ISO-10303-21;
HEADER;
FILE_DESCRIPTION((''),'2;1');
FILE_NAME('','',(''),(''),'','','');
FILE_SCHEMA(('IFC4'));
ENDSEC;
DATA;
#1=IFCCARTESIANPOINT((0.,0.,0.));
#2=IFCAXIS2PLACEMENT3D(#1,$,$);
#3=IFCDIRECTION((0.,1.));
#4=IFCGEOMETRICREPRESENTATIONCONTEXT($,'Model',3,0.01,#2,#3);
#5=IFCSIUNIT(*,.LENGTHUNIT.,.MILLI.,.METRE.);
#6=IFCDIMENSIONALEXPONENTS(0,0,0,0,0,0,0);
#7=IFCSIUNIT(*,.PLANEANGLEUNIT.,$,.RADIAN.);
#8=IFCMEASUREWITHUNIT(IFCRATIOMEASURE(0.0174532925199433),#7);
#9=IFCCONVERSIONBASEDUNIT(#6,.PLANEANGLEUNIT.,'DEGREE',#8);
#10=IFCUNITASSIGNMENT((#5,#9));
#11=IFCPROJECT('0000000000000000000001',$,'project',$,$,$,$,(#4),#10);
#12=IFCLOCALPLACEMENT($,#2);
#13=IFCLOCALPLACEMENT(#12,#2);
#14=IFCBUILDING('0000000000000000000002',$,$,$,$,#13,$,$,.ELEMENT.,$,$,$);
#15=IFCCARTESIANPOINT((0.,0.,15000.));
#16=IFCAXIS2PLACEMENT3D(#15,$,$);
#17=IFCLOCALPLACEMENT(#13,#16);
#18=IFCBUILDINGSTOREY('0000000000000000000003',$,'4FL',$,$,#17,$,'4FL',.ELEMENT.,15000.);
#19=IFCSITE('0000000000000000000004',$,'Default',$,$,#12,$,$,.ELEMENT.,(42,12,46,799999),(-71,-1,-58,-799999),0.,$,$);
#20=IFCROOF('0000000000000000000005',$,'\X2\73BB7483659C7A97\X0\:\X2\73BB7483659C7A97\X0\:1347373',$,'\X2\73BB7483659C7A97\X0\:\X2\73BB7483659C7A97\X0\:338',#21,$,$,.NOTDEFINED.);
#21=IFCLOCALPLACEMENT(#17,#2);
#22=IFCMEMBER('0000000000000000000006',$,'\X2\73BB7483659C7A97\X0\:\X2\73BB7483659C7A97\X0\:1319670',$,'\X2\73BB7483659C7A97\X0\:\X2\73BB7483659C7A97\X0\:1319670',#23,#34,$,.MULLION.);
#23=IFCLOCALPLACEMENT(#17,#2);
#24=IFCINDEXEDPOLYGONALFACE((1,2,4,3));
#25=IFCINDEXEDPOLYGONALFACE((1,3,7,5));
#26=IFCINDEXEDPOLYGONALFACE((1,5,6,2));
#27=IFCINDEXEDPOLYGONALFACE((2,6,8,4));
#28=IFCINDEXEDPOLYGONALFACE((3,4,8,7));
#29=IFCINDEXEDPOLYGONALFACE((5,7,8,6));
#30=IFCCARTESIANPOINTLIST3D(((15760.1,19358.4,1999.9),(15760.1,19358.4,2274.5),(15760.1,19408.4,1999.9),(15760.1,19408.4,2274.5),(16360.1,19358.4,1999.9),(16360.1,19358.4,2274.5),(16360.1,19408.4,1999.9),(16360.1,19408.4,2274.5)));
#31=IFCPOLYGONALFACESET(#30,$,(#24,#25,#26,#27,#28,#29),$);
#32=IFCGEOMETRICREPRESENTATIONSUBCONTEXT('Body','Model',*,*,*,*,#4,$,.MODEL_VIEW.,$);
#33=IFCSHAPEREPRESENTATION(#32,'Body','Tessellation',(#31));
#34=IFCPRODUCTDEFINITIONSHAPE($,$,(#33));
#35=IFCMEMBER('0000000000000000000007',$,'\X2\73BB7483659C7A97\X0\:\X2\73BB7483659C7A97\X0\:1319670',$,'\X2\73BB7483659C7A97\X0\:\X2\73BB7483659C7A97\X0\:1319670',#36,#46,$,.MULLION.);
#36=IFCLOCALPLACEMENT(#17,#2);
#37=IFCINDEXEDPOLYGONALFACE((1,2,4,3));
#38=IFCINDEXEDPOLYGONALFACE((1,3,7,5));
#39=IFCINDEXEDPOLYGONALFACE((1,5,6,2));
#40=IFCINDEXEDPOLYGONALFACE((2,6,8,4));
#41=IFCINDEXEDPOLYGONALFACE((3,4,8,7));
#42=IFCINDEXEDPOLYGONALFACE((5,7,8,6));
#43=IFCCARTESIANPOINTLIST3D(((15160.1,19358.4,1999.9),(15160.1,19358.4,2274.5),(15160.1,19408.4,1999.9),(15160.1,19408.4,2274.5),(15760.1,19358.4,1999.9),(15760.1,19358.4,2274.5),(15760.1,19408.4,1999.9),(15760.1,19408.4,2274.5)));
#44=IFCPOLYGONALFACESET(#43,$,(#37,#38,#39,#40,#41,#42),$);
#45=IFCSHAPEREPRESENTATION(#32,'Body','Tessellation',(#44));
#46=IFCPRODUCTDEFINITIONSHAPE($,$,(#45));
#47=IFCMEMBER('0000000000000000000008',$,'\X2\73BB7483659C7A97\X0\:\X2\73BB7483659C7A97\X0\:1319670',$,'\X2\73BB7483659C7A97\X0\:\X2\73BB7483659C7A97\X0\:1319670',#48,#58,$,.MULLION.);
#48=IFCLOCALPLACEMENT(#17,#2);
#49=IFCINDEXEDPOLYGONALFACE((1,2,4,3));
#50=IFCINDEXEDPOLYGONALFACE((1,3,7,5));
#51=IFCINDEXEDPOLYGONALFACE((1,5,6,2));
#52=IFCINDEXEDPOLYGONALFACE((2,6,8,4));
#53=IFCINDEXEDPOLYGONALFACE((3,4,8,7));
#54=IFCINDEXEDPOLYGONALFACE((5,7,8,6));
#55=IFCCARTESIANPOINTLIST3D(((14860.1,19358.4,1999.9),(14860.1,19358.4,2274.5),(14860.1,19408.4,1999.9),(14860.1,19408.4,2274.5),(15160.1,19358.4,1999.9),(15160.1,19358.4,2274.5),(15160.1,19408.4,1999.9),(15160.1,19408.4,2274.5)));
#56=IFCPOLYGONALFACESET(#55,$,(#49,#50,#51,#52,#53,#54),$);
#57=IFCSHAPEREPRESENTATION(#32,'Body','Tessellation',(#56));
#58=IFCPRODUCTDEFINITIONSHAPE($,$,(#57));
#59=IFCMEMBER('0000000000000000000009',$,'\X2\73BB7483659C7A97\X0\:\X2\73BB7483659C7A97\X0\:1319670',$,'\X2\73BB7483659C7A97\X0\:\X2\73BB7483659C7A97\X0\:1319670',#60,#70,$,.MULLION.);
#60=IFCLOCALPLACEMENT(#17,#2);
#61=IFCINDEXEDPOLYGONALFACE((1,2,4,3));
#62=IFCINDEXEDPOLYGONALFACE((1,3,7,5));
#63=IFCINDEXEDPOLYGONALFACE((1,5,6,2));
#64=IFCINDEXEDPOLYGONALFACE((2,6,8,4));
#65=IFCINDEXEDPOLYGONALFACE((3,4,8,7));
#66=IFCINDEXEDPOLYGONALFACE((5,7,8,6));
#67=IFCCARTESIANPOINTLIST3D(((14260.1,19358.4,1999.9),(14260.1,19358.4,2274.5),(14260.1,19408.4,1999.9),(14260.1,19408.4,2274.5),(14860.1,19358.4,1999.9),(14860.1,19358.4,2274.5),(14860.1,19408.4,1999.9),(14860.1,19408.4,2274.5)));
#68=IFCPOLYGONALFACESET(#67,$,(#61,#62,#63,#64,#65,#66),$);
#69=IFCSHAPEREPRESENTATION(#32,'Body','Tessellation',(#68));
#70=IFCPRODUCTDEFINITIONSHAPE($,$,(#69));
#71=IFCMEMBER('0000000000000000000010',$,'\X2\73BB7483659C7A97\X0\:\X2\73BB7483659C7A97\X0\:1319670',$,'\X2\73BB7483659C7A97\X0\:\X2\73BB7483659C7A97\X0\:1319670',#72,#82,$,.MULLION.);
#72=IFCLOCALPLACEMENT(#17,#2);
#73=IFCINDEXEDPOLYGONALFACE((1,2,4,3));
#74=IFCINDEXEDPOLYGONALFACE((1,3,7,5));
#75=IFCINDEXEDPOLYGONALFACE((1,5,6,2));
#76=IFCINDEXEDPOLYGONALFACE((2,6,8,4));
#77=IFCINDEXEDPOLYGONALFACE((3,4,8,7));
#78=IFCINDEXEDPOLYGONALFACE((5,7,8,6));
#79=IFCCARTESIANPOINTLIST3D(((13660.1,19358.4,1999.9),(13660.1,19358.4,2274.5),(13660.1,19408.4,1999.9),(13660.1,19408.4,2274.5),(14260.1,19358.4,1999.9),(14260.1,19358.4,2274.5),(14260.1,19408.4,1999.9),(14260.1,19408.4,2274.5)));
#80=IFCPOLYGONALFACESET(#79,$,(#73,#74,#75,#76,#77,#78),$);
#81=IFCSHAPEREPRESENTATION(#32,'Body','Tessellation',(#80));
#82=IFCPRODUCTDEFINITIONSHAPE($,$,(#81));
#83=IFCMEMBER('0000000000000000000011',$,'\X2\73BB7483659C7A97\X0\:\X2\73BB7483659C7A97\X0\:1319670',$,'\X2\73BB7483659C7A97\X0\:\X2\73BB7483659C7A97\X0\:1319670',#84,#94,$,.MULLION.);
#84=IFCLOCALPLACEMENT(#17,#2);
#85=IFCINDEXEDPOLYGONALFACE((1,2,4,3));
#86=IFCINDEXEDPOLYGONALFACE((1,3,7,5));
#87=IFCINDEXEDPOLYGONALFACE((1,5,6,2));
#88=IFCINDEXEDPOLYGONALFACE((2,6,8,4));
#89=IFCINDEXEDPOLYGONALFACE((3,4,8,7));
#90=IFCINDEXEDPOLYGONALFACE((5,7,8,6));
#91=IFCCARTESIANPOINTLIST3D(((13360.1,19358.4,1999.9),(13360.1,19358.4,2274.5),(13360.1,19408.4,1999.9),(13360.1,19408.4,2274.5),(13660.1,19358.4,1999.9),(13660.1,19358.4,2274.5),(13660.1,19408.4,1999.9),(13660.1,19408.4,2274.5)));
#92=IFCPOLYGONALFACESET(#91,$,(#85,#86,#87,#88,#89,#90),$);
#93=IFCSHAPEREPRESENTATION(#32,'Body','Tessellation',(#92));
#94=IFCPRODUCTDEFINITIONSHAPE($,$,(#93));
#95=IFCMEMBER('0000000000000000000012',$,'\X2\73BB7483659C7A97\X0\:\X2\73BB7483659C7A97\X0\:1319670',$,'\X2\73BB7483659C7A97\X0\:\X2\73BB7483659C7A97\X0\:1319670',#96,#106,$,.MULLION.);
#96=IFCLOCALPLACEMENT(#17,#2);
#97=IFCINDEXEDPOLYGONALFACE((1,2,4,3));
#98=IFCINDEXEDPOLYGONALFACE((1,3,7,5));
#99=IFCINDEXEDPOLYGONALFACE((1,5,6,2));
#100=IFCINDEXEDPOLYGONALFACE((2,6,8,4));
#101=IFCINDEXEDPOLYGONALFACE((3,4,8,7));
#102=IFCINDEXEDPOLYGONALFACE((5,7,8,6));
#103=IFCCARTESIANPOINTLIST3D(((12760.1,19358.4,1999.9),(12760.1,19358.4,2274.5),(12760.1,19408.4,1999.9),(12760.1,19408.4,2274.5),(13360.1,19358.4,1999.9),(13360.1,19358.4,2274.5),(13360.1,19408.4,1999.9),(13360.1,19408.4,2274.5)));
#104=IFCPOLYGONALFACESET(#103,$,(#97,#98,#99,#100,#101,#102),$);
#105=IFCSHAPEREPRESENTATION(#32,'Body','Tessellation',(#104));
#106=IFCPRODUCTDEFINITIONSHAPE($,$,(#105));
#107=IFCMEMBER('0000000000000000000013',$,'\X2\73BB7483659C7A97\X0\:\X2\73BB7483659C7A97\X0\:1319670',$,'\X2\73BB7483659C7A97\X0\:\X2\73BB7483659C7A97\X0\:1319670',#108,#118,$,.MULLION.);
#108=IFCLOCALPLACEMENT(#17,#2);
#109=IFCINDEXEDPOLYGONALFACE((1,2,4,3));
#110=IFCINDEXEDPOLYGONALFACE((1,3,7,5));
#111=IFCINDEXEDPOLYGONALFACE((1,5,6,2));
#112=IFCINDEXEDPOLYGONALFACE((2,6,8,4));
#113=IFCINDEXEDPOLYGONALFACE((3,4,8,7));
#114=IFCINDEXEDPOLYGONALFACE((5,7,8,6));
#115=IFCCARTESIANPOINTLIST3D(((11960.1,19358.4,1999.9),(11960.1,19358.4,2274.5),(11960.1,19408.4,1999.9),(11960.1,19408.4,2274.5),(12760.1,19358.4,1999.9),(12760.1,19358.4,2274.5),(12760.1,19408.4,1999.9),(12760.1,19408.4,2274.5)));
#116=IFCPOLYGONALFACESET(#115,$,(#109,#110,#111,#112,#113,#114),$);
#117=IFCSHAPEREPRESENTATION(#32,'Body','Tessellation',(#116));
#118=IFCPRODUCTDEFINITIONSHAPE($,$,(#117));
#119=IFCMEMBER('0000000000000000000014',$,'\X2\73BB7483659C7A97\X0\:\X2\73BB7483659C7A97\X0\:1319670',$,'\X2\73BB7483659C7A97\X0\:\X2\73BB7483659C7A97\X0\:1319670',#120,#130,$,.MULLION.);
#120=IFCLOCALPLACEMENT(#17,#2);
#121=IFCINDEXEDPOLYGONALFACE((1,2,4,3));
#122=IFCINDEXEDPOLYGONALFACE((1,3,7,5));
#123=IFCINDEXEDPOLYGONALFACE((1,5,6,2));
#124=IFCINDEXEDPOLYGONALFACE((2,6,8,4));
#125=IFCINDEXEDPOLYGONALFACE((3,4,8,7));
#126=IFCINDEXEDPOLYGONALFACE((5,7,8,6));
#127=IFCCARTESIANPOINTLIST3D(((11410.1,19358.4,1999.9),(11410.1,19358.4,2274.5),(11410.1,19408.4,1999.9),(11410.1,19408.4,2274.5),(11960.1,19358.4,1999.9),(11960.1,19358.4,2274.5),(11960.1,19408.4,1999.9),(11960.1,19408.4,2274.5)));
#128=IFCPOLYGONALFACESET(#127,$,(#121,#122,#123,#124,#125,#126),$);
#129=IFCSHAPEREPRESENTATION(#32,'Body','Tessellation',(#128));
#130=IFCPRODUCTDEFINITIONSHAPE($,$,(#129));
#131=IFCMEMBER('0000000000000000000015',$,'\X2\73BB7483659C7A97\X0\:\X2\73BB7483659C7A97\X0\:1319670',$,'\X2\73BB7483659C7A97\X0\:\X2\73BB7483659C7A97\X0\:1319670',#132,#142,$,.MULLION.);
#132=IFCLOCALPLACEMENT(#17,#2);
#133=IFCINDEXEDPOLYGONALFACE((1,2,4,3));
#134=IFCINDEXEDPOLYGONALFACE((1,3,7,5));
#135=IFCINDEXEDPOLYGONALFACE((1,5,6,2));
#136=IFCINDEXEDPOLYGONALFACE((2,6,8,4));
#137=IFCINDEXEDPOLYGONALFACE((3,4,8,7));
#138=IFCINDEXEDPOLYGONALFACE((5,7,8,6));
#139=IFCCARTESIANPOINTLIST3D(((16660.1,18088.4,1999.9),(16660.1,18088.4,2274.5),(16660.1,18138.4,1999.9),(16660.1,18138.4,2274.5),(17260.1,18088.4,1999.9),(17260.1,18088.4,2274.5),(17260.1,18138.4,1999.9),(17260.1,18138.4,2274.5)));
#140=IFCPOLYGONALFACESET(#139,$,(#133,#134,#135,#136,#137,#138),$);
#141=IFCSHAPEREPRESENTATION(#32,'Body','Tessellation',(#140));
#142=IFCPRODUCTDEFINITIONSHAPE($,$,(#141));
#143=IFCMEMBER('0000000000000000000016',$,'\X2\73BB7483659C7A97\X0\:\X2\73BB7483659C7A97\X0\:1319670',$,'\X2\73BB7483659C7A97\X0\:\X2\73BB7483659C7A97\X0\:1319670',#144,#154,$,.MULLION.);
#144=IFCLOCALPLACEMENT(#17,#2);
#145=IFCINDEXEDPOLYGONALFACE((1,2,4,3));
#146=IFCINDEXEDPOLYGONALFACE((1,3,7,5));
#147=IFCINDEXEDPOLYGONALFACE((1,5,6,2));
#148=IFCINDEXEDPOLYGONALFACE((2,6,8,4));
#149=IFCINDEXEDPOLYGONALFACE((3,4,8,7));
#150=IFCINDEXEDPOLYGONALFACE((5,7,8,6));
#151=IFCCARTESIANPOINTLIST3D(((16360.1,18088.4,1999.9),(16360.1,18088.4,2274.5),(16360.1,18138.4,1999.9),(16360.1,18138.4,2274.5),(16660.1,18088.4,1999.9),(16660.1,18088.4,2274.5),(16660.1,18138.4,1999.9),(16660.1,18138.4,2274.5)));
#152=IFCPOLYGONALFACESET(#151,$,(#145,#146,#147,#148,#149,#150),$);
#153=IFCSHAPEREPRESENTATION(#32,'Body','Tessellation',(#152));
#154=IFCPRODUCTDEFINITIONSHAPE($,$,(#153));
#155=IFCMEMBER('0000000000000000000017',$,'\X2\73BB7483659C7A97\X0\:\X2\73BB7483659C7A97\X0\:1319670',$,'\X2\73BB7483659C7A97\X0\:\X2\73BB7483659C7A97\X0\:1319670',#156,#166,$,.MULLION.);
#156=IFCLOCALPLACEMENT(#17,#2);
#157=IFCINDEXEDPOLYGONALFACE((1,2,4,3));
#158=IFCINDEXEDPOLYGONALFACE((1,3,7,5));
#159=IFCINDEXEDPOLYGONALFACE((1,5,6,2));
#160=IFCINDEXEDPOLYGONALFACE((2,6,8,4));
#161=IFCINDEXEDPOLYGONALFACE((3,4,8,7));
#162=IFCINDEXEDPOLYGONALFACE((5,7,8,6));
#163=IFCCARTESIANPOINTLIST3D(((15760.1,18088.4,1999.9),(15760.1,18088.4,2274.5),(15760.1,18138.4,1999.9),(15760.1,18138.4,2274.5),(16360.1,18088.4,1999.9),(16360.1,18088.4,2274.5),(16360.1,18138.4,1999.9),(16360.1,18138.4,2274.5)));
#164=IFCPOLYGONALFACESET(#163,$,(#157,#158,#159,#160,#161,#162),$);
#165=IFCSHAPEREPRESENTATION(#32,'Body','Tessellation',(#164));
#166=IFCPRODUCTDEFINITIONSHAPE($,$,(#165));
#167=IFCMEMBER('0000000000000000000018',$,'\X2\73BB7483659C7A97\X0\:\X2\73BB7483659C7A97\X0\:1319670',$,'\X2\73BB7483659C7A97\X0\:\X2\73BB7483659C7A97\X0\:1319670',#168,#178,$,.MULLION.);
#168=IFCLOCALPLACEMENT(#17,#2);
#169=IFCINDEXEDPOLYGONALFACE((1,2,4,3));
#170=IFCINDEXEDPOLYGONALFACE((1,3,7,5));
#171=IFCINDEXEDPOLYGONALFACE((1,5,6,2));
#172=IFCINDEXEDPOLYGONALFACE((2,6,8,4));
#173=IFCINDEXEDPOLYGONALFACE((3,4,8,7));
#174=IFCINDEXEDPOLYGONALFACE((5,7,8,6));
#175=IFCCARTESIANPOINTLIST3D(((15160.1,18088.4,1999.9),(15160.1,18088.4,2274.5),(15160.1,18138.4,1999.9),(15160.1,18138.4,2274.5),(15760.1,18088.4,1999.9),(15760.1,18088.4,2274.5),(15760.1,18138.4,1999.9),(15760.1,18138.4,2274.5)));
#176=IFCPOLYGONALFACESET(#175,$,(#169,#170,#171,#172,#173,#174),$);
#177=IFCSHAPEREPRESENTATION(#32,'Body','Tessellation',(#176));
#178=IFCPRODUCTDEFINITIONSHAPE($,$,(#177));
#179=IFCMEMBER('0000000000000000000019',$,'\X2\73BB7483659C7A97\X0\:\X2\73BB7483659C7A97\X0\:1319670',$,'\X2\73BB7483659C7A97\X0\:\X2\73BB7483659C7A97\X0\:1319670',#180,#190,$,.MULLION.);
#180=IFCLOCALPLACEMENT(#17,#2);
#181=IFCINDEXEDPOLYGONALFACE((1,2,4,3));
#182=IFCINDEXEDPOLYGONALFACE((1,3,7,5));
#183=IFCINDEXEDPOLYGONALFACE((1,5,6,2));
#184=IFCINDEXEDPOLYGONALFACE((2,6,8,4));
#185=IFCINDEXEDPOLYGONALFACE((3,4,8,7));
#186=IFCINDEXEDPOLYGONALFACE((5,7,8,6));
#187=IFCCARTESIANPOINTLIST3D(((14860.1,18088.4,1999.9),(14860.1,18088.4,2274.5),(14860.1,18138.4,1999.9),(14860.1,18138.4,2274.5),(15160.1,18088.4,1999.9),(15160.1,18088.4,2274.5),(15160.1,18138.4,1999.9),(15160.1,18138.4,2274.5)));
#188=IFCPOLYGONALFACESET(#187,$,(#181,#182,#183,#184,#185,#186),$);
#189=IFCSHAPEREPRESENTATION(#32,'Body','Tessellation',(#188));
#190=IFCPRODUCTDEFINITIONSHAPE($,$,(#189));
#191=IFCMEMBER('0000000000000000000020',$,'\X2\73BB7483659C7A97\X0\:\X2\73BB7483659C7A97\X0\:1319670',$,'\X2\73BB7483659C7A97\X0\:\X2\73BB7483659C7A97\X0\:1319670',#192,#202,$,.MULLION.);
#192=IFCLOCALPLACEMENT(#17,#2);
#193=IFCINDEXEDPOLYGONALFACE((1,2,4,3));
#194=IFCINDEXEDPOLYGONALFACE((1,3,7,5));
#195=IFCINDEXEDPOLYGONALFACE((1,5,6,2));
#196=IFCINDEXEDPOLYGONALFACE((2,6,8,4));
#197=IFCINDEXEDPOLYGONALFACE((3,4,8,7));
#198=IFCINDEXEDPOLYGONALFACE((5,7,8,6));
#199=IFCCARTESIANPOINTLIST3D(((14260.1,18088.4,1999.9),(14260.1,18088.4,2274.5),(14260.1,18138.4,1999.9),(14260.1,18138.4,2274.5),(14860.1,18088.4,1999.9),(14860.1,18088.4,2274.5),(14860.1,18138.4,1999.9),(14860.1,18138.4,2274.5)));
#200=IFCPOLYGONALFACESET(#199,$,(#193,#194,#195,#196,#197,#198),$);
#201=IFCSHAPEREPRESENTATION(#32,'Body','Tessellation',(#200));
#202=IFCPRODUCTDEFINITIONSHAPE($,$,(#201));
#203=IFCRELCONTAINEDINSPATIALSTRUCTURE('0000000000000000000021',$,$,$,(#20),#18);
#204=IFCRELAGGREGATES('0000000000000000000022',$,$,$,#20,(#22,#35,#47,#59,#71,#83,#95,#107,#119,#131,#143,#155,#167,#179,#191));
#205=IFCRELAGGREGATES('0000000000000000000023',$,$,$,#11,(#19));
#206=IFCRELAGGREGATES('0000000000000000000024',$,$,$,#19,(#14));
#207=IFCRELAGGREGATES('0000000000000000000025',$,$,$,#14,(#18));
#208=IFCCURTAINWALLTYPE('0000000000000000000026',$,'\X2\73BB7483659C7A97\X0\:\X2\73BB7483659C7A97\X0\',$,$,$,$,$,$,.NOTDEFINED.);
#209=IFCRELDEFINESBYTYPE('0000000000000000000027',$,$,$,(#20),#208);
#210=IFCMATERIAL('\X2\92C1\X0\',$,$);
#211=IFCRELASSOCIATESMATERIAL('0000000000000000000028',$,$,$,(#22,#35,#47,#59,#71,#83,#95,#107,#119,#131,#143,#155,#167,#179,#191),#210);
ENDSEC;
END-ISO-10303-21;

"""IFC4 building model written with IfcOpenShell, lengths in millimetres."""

from ifc_helpers import new_model, entity, si_unit, converted_unit, direction, frame, frame_2d, origin, place, context, subcontext, project, spatial, rectangle, extrude, material, type_object, element, aggregate, save


model = new_model("IFC4")

# Units and contexts
model_context = context("Model", 3, precision=0.01, world=origin(), true_north=direction((0.0, 1.0)))
body_context = subcontext(model_context, "Body", "Model", "MODEL_VIEW")
ifc_project = project(units=[si_unit("LENGTHUNIT", "METRE", prefix="MILLI"), converted_unit("PLANEANGLEUNIT", "DEGREE", entity("IfcRatioMeasure", 0.0174532925199433), si_unit("PLANEANGLEUNIT", "RADIAN"), dimensions=[0, 0, 0, 0, 0, 0, 0])], contexts=[model_context])

# Site, building, storey
site_placement = place(None, origin())
site = spatial("IfcSite", under=ifc_project, at=site_placement, Name="Default", CompositionType="ELEMENT", RefLatitude=(42, 12, 46, 799999), RefLongitude=(-71, -1, -58, -799999), RefElevation=0.0)
building_placement = place(site_placement, origin())
building = spatial("IfcBuilding", under=site, at=building_placement, CompositionType="ELEMENT")
storey_placement = place(building_placement, frame((0.0, 0.0, 15000.0)))
storey = spatial("IfcBuildingStorey", under=building, at=storey_placement, Name="4FL", LongName="4FL", CompositionType="ELEMENT", Elevation=15000.0)

# Roof, members
curtain_wall_type = type_object("IfcCurtainWallType", Name="玻璃斜窗:玻璃斜窗", PredefinedType="NOTDEFINED")
roof_1_placement = place(storey_placement, frame((0.0, 0.0, -15000.0)))
roof_1 = element("IfcRoof", 1, at=roof_1_placement, inside=storey, type_object=curtain_wall_type, Name="玻璃斜窗:玻璃斜窗:1347373", ObjectType="玻璃斜窗:玻璃斜窗:338", PredefinedType="NOTDEFINED")
ifc_material = material(Name="鋁")
member_1_placement = place(roof_1_placement, frame((0.0, 0.0, 15000.0)))
member_1 = element("IfcMember", 2, at=member_1_placement, material=ifc_material, Name="玻璃斜窗:玻璃斜窗:1319670", ObjectType="玻璃斜窗:玻璃斜窗:1319670", PredefinedType="MULLION", context=body_context, shape_type="SweptSolid", body=[
    extrude(rectangle(XDim=274.5, YDim=50.0, at=frame_2d((0.0, 0.0), x_axis=(1.0, 0.0))), frame((15760.1, 19383.4, 2137.2), z_axis=(1.0, 0.0, 0.0), x_axis=(0.0, 0.0, -1.0)), (0.0, 0.0, 1.0), 600.0),
])
member_2_placement = place(roof_1_placement, frame((0.0, 0.0, 15000.0)))
member_2 = element("IfcMember", 3, at=member_2_placement, material=ifc_material, Name="玻璃斜窗:玻璃斜窗:1319670", ObjectType="玻璃斜窗:玻璃斜窗:1319670", PredefinedType="MULLION", context=body_context, shape_type="SweptSolid", body=[
    extrude(rectangle(XDim=274.5, YDim=50.0, at=frame_2d((0.0, 0.0), x_axis=(1.0, 0.0))), frame((15160.1, 19383.4, 2137.2), z_axis=(1.0, 0.0, 0.0), x_axis=(0.0, 0.0, -1.0)), (0.0, 0.0, 1.0), 600.0),
])
member_3_placement = place(roof_1_placement, frame((0.0, 0.0, 15000.0)))
member_3 = element("IfcMember", 4, at=member_3_placement, material=ifc_material, Name="玻璃斜窗:玻璃斜窗:1319670", ObjectType="玻璃斜窗:玻璃斜窗:1319670", PredefinedType="MULLION", context=body_context, shape_type="SweptSolid", body=[
    extrude(rectangle(XDim=274.5, YDim=50.0, at=frame_2d((0.0, 0.0), x_axis=(1.0, 0.0))), frame((14860.1, 19383.4, 2137.2), z_axis=(1.0, 0.0, 0.0), x_axis=(0.0, 0.0, -1.0)), (0.0, 0.0, 1.0), 300.0),
])
member_4_placement = place(roof_1_placement, frame((0.0, 0.0, 15000.0)))
member_4 = element("IfcMember", 5, at=member_4_placement, material=ifc_material, Name="玻璃斜窗:玻璃斜窗:1319670", ObjectType="玻璃斜窗:玻璃斜窗:1319670", PredefinedType="MULLION", context=body_context, shape_type="SweptSolid", body=[
    extrude(rectangle(XDim=274.5, YDim=50.0, at=frame_2d((0.0, 0.0), x_axis=(1.0, 0.0))), frame((14260.1, 19383.4, 2137.2), z_axis=(1.0, 0.0, 0.0), x_axis=(0.0, 0.0, -1.0)), (0.0, 0.0, 1.0), 600.0),
])
member_5_placement = place(roof_1_placement, frame((0.0, 0.0, 15000.0)))
member_5 = element("IfcMember", 6, at=member_5_placement, material=ifc_material, Name="玻璃斜窗:玻璃斜窗:1319670", ObjectType="玻璃斜窗:玻璃斜窗:1319670", PredefinedType="MULLION", context=body_context, shape_type="SweptSolid", body=[
    extrude(rectangle(XDim=274.5, YDim=50.0, at=frame_2d((0.0, 0.0), x_axis=(1.0, 0.0))), frame((13660.1, 19383.4, 2137.2), z_axis=(1.0, 0.0, 0.0), x_axis=(0.0, 0.0, -1.0)), (0.0, 0.0, 1.0), 600.0),
])
member_6_placement = place(roof_1_placement, frame((0.0, 0.0, 15000.0)))
member_6 = element("IfcMember", 7, at=member_6_placement, material=ifc_material, Name="玻璃斜窗:玻璃斜窗:1319670", ObjectType="玻璃斜窗:玻璃斜窗:1319670", PredefinedType="MULLION", context=body_context, shape_type="SweptSolid", body=[
    extrude(rectangle(XDim=274.5, YDim=50.0, at=frame_2d((0.0, 0.0), x_axis=(1.0, 0.0))), frame((13360.1, 19383.4, 2137.2), z_axis=(1.0, 0.0, 0.0), x_axis=(0.0, 0.0, -1.0)), (0.0, 0.0, 1.0), 300.0),
])
member_7_placement = place(roof_1_placement, frame((0.0, 0.0, 15000.0)))
member_7 = element("IfcMember", 8, at=member_7_placement, material=ifc_material, Name="玻璃斜窗:玻璃斜窗:1319670", ObjectType="玻璃斜窗:玻璃斜窗:1319670", PredefinedType="MULLION", context=body_context, shape_type="SweptSolid", body=[
    extrude(rectangle(XDim=274.5, YDim=50.0, at=frame_2d((0.0, 0.0), x_axis=(1.0, 0.0))), frame((12760.1, 19383.4, 2137.2), z_axis=(1.0, 0.0, 0.0), x_axis=(0.0, 0.0, -1.0)), (0.0, 0.0, 1.0), 600.0),
])
member_8_placement = place(roof_1_placement, frame((0.0, 0.0, 15000.0)))
member_8 = element("IfcMember", 9, at=member_8_placement, material=ifc_material, Name="玻璃斜窗:玻璃斜窗:1319670", ObjectType="玻璃斜窗:玻璃斜窗:1319670", PredefinedType="MULLION", context=body_context, shape_type="SweptSolid", body=[
    extrude(rectangle(XDim=274.5, YDim=50.0, at=frame_2d((0.0, 0.0), x_axis=(1.0, 0.0))), frame((11960.1, 19383.4, 2137.2), z_axis=(1.0, 0.0, 0.0), x_axis=(0.0, 0.0, -1.0)), (0.0, 0.0, 1.0), 800.0),
])
member_9_placement = place(roof_1_placement, frame((0.0, 0.0, 15000.0)))
member_9 = element("IfcMember", 10, at=member_9_placement, material=ifc_material, Name="玻璃斜窗:玻璃斜窗:1319670", ObjectType="玻璃斜窗:玻璃斜窗:1319670", PredefinedType="MULLION", context=body_context, shape_type="SweptSolid", body=[
    extrude(rectangle(XDim=274.5, YDim=50.0, at=frame_2d((0.0, 0.0), x_axis=(1.0, 0.0))), frame((11410.1, 19383.4, 2137.2), z_axis=(1.0, 0.0, 0.0), x_axis=(0.0, 0.0, -1.0)), (0.0, 0.0, 1.0), 550.0),
])
member_10_placement = place(roof_1_placement, frame((0.0, 0.0, 15000.0)))
member_10 = element("IfcMember", 11, at=member_10_placement, material=ifc_material, Name="玻璃斜窗:玻璃斜窗:1319670", ObjectType="玻璃斜窗:玻璃斜窗:1319670", PredefinedType="MULLION", context=body_context, shape_type="SweptSolid", body=[
    extrude(rectangle(XDim=274.5, YDim=50.0, at=frame_2d((0.0, 0.0), x_axis=(1.0, 0.0))), frame((17260.1, 18113.4, 2137.2), z_axis=(-1.0, 0.0, 0.0), x_axis=(0.0, 0.0, -1.0)), (0.0, 0.0, 1.0), 600.0),
])
member_11_placement = place(roof_1_placement, frame((0.0, 0.0, 15000.0)))
member_11 = element("IfcMember", 12, at=member_11_placement, material=ifc_material, Name="玻璃斜窗:玻璃斜窗:1319670", ObjectType="玻璃斜窗:玻璃斜窗:1319670", PredefinedType="MULLION", context=body_context, shape_type="SweptSolid", body=[
    extrude(rectangle(XDim=274.5, YDim=50.0, at=frame_2d((0.0, 0.0), x_axis=(1.0, 0.0))), frame((16660.1, 18113.4, 2137.2), z_axis=(-1.0, 0.0, 0.0), x_axis=(0.0, 0.0, -1.0)), (0.0, 0.0, 1.0), 300.0),
])
member_12_placement = place(roof_1_placement, frame((0.0, 0.0, 15000.0)))
member_12 = element("IfcMember", 13, at=member_12_placement, material=ifc_material, Name="玻璃斜窗:玻璃斜窗:1319670", ObjectType="玻璃斜窗:玻璃斜窗:1319670", PredefinedType="MULLION", context=body_context, shape_type="SweptSolid", body=[
    extrude(rectangle(XDim=274.5, YDim=50.0, at=frame_2d((0.0, 0.0), x_axis=(1.0, 0.0))), frame((16360.1, 18113.4, 2137.2), z_axis=(-1.0, 0.0, 0.0), x_axis=(0.0, 0.0, -1.0)), (0.0, 0.0, 1.0), 600.0),
])
member_13_placement = place(roof_1_placement, frame((0.0, 0.0, 15000.0)))
member_13 = element("IfcMember", 14, at=member_13_placement, material=ifc_material, Name="玻璃斜窗:玻璃斜窗:1319670", ObjectType="玻璃斜窗:玻璃斜窗:1319670", PredefinedType="MULLION", context=body_context, shape_type="SweptSolid", body=[
    extrude(rectangle(XDim=274.5, YDim=50.0, at=frame_2d((0.0, 0.0), x_axis=(1.0, 0.0))), frame((15760.1, 18113.4, 2137.2), z_axis=(-1.0, 0.0, 0.0), x_axis=(0.0, 0.0, -1.0)), (0.0, 0.0, 1.0), 600.0),
])
member_14_placement = place(roof_1_placement, frame((0.0, 0.0, 15000.0)))
member_14 = element("IfcMember", 15, at=member_14_placement, material=ifc_material, Name="玻璃斜窗:玻璃斜窗:1319670", ObjectType="玻璃斜窗:玻璃斜窗:1319670", PredefinedType="MULLION", context=body_context, shape_type="SweptSolid", body=[
    extrude(rectangle(XDim=274.5, YDim=50.0, at=frame_2d((0.0, 0.0), x_axis=(1.0, 0.0))), frame((15160.1, 18113.4, 2137.2), z_axis=(-1.0, 0.0, 0.0), x_axis=(0.0, 0.0, -1.0)), (0.0, 0.0, 1.0), 300.0),
])
member_15_placement = place(roof_1_placement, frame((0.0, 0.0, 15000.0)))
member_15 = element("IfcMember", 16, at=member_15_placement, material=ifc_material, Name="玻璃斜窗:玻璃斜窗:1319670", ObjectType="玻璃斜窗:玻璃斜窗:1319670", PredefinedType="MULLION", context=body_context, shape_type="SweptSolid", body=[
    extrude(rectangle(XDim=274.5, YDim=50.0, at=frame_2d((0.0, 0.0), x_axis=(1.0, 0.0))), frame((14860.1, 18113.4, 2137.2), z_axis=(-1.0, 0.0, 0.0), x_axis=(0.0, 0.0, -1.0)), (0.0, 0.0, 1.0), 600.0),
])
aggregate(roof_1, [member_1, member_2, member_3, member_4, member_5, member_6, member_7, member_8, member_9, member_10, member_11, member_12, member_13, member_14, member_15])

save(model, "model.ifc")
